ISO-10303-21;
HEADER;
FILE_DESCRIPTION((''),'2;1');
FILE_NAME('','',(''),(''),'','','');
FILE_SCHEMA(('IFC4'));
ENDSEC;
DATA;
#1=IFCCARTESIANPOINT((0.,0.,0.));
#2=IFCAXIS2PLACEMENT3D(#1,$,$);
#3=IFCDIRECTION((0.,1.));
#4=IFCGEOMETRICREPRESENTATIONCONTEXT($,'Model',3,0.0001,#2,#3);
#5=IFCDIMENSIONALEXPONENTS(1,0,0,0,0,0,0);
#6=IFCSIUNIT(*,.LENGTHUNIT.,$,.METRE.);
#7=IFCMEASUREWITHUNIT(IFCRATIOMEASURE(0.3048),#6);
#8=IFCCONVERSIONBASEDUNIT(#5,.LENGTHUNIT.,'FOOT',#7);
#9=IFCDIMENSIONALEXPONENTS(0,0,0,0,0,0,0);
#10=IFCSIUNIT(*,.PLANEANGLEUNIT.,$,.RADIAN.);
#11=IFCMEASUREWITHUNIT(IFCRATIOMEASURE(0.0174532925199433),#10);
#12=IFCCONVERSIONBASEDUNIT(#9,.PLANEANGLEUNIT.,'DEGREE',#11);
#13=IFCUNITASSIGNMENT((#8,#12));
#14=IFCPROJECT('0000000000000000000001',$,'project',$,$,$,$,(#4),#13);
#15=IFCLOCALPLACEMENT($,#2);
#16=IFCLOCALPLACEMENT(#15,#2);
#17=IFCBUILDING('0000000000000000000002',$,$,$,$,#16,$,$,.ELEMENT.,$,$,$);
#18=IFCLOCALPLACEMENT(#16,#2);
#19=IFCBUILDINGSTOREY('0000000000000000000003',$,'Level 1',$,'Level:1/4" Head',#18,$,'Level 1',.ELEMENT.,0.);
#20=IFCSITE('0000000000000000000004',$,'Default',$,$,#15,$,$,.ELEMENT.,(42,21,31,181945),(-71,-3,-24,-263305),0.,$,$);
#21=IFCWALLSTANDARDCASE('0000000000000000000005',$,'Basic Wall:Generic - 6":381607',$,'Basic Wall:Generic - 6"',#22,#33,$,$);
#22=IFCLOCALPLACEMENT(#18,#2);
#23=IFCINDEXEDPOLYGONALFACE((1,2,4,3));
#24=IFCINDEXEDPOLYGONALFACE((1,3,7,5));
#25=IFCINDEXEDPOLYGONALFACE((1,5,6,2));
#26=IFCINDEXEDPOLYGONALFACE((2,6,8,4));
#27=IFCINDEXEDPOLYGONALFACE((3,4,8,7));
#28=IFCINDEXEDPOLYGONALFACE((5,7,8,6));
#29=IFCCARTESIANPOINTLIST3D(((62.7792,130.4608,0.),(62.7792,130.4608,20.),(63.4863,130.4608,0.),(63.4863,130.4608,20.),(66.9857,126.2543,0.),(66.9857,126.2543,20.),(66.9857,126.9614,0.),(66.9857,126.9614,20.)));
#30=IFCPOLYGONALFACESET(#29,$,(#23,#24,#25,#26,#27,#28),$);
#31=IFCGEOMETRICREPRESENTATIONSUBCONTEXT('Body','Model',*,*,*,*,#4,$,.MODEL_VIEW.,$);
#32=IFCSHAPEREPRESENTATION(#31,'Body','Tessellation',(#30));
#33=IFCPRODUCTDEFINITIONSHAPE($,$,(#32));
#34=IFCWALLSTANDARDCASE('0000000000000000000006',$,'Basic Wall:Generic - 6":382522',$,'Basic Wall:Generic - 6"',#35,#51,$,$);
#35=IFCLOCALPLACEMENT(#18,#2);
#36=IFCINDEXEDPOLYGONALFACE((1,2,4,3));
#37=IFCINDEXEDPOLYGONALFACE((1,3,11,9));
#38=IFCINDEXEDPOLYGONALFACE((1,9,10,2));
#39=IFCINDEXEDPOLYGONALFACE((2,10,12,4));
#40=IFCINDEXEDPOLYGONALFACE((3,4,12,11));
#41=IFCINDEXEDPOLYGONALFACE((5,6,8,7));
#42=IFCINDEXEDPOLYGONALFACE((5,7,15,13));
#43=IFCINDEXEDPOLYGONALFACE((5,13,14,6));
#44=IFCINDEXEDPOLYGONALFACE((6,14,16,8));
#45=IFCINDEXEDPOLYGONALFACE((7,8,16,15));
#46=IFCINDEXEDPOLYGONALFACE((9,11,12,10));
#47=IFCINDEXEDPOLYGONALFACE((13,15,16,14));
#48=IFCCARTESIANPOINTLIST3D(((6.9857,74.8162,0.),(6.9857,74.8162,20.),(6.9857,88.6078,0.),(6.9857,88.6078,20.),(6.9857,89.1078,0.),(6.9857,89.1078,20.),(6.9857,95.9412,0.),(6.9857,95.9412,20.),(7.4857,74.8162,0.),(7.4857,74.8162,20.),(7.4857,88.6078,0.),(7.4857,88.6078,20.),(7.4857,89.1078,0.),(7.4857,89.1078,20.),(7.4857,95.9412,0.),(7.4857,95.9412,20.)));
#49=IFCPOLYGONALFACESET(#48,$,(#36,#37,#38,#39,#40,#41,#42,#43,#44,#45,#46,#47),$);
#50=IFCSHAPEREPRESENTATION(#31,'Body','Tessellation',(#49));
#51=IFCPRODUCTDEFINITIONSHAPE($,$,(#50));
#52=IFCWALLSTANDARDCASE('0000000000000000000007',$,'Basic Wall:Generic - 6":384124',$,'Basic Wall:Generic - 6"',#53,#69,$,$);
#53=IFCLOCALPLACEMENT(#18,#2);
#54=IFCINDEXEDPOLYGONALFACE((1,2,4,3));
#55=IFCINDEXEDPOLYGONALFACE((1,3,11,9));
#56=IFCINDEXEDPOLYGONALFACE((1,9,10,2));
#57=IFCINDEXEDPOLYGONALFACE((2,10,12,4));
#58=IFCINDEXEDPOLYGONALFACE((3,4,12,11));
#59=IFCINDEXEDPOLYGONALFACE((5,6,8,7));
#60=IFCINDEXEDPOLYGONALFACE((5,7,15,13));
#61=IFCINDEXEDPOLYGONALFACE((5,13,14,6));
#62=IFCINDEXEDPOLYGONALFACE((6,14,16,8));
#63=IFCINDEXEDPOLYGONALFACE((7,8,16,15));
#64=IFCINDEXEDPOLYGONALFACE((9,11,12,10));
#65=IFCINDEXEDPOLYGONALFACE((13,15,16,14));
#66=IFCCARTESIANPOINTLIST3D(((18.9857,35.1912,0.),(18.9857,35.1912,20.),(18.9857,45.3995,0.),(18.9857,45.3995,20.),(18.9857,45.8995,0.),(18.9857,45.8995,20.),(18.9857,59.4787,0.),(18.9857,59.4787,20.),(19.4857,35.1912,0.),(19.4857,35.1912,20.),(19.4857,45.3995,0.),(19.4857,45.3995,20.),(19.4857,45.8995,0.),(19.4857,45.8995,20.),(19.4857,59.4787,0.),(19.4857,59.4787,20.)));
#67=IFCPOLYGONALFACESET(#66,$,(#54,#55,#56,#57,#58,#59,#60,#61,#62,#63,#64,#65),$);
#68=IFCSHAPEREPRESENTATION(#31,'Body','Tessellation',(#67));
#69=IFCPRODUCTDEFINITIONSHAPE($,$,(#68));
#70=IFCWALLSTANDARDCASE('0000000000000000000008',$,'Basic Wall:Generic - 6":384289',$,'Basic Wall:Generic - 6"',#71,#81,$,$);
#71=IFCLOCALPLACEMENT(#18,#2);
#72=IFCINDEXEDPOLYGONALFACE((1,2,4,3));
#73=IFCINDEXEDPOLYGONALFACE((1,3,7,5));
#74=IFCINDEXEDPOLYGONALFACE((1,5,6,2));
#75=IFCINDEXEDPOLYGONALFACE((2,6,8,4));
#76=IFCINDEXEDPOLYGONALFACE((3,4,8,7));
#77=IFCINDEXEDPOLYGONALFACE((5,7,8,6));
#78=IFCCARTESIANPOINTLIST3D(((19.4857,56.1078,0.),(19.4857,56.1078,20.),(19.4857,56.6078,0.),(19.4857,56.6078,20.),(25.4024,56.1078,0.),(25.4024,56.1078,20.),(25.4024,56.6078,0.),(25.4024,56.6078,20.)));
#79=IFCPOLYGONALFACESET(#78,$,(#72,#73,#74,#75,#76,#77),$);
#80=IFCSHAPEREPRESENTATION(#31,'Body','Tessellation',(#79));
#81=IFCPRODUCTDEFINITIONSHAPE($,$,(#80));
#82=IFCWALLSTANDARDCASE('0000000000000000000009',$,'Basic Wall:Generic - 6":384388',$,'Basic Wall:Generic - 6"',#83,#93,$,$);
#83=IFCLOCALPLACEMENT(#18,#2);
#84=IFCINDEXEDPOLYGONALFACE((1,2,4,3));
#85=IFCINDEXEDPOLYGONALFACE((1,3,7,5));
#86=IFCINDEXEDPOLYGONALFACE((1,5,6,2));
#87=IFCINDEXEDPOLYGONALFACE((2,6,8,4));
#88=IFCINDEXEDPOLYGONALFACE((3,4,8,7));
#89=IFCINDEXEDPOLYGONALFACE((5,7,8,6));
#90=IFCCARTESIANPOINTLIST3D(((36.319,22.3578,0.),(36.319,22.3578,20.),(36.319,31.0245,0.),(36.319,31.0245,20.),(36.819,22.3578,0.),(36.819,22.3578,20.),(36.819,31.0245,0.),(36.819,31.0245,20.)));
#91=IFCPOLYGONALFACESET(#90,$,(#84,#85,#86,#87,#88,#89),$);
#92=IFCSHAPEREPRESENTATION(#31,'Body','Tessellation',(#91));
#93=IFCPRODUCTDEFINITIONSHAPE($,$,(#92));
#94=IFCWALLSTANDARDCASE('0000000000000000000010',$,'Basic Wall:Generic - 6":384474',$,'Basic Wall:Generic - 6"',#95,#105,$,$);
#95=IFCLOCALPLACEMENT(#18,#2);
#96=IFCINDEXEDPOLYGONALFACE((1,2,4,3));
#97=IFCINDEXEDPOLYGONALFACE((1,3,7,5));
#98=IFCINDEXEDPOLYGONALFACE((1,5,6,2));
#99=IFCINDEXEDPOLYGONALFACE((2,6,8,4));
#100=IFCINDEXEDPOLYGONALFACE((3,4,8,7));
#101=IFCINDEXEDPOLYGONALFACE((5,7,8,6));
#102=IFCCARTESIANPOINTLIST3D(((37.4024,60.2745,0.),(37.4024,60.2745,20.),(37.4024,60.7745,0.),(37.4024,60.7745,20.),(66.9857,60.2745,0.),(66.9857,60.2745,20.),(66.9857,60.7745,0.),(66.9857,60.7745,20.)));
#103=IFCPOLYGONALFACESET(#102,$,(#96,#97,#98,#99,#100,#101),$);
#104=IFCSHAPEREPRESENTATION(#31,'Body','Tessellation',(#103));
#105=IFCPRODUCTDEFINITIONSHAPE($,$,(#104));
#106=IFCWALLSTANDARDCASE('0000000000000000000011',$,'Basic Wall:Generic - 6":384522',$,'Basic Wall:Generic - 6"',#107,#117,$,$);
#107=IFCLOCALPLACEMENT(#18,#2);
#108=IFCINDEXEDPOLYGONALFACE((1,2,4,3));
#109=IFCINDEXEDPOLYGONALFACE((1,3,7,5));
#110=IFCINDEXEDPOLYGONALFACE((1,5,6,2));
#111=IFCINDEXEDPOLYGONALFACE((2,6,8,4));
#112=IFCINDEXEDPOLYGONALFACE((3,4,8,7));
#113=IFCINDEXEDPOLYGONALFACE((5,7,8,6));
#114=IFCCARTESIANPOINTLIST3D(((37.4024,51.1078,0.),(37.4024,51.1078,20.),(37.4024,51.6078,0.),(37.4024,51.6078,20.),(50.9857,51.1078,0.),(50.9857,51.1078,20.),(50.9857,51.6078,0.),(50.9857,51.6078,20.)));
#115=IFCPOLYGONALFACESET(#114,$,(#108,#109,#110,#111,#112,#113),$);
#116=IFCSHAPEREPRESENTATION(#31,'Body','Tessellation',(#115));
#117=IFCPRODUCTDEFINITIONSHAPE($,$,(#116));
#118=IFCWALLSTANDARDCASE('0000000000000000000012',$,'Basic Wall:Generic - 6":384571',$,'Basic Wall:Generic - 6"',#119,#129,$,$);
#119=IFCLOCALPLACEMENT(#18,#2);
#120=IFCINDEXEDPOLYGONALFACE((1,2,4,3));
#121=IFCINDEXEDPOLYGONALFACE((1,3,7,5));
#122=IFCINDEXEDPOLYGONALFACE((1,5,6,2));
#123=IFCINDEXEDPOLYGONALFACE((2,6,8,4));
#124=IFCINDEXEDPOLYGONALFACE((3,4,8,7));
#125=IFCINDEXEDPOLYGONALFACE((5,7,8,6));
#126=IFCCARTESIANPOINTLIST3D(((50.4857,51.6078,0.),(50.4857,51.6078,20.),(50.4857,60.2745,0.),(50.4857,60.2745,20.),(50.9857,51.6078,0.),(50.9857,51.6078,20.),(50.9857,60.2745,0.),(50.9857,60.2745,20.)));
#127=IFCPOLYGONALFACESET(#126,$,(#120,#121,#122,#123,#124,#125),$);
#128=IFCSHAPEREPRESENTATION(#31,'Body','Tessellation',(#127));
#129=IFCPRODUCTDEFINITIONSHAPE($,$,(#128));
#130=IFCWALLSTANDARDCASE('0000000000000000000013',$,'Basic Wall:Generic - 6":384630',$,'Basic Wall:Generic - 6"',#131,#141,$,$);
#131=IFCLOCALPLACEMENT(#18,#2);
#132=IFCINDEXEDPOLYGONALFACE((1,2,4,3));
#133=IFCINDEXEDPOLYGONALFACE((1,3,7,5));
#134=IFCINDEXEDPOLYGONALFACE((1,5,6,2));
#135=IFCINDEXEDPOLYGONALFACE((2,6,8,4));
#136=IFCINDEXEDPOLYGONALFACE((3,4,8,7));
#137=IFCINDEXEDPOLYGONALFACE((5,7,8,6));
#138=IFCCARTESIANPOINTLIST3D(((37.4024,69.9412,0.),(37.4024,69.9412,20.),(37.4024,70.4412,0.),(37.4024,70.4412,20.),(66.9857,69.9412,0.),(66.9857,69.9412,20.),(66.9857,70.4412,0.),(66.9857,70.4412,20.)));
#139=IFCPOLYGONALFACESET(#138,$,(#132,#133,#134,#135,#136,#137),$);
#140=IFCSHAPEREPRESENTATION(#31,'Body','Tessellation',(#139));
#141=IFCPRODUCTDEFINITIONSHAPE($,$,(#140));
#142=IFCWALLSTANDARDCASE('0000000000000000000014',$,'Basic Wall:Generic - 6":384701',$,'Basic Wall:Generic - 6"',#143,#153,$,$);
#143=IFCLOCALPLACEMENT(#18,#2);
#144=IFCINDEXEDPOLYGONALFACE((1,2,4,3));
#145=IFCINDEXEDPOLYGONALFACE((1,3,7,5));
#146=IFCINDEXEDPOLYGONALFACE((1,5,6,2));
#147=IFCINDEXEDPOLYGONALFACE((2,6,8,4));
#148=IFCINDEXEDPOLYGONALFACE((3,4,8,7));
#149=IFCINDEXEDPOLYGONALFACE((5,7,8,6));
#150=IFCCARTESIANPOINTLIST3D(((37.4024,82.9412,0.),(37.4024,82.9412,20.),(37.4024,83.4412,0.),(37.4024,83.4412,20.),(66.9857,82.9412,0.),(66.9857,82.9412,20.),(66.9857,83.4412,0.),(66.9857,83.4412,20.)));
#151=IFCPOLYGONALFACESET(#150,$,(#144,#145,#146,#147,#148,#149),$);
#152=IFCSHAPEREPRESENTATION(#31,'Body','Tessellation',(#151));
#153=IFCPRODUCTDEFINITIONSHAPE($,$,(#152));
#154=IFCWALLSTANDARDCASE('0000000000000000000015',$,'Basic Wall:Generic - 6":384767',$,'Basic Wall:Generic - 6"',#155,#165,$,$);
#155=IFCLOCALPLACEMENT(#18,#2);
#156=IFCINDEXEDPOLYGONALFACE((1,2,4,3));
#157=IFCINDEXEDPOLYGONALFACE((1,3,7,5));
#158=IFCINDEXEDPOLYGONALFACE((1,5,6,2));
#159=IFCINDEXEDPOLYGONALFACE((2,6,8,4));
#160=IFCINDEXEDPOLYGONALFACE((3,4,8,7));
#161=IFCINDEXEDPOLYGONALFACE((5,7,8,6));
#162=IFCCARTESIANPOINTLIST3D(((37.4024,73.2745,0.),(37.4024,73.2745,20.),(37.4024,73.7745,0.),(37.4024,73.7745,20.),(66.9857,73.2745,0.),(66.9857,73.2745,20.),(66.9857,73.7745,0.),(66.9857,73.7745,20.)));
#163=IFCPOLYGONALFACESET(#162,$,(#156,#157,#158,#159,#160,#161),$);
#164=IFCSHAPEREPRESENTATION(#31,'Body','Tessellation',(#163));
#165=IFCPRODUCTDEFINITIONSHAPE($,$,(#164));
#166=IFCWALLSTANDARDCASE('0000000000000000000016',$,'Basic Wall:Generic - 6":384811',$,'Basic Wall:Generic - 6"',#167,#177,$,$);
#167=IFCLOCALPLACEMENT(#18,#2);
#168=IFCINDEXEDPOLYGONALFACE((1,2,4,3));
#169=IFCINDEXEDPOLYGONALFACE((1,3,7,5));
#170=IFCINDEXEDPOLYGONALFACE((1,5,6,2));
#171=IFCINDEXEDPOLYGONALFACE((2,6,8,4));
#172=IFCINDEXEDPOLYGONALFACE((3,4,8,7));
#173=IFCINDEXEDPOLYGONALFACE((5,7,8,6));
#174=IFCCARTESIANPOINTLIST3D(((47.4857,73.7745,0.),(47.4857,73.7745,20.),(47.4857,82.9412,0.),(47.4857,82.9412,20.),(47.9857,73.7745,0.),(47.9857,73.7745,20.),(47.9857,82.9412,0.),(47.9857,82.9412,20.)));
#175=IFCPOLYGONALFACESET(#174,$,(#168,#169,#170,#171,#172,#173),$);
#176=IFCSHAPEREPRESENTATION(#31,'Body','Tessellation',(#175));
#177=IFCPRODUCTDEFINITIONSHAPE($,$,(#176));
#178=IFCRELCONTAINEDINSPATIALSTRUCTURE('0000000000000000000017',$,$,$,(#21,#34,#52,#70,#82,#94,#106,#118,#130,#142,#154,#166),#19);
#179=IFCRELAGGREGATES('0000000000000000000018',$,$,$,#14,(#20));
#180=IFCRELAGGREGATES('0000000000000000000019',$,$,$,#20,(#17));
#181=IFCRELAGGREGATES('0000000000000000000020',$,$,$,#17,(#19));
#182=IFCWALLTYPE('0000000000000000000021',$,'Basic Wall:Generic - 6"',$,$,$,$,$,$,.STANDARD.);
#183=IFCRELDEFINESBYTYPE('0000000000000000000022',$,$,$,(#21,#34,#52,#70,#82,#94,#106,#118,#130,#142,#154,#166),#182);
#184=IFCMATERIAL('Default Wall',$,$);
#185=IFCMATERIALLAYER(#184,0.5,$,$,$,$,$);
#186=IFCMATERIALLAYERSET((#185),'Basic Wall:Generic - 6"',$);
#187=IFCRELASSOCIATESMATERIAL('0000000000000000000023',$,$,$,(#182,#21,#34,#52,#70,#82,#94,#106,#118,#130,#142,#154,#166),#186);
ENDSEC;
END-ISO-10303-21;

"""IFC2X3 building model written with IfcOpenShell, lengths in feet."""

from ifc_helpers import new_model, entity, si_unit, converted_unit, direction, frame, frame_2d, origin, origin_2d_with_axis, place, context, subcontext, project, spatial, polyline, rectangle, outline, extrude, material, layer, layer_set, layer_usage, type_object, element, save


model = new_model("IFC2X3")

# Units and contexts
model_context = context("Model", 3, precision=0.0001, world=origin(), true_north=direction((0.0, 1.0)))
body_context = subcontext(model_context, "Body", "Model", "MODEL_VIEW")
ifc_project = project(units=[converted_unit("LENGTHUNIT", "FOOT", entity("IfcRatioMeasure", 0.3048), si_unit("LENGTHUNIT", "METRE"), dimensions=[1, 0, 0, 0, 0, 0, 0]), converted_unit("PLANEANGLEUNIT", "DEGREE", entity("IfcRatioMeasure", 0.0174532925199433), si_unit("PLANEANGLEUNIT", "RADIAN"), dimensions=[0, 0, 0, 0, 0, 0, 0])], contexts=[model_context])

# Site, building, storey
site_placement = place(None, origin())
site = spatial("IfcSite", under=ifc_project, at=site_placement, Name="Default", CompositionType="ELEMENT", RefLatitude=(42, 21, 31, 181945), RefLongitude=(-71, -3, -24, -263305), RefElevation=0.0)
building_placement = place(site_placement, origin())
building = spatial("IfcBuilding", under=site, at=building_placement, CompositionType="ELEMENT")
storey_placement = place(building_placement, origin())
storey = spatial("IfcBuildingStorey", under=building, at=storey_placement, Name="Level 1", ObjectType="Level:1/4\" Head", LongName="Level 1", CompositionType="ELEMENT", Elevation=0.0)

# Wall
ifc_material = material(Name="Default Wall")
ifc_layer_1 = layer(ifc_material, 0.5)
ifc_layer_set_1 = layer_set([ifc_layer_1], Name="Basic Wall:Generic - 6\"")
wall_type_1 = type_object("IfcWallType", Name="Basic Wall:Generic - 6\"", PredefinedType="STANDARD", material=ifc_layer_set_1)
ifc_layer_usage_1 = layer_usage(ifc_layer_set_1, "AXIS2", "NEGATIVE", 0.25)
wall_1_placement = place(storey_placement, frame((67.1625, 126.4311, 0.0), z_axis=(0.0, 0.0, 1.0), x_axis=(-0.707107, 0.707107, 0.0)))
element("IfcWallStandardCase", 1, at=wall_1_placement, inside=storey, type_object=wall_type_1, material=ifc_layer_usage_1, Name="Basic Wall:Generic - 6\":381607", ObjectType="Basic Wall:Generic - 6\"", context=body_context, shape_type="SweptSolid", body=[
    extrude(outline(polyline([(5.4489, -0.25), (5.9489, 0.25), (0.0, 0.25), (0.5, -0.25), (5.4489, -0.25)])), origin(), (0.0, 0.0, 1.0), 20.0),
])

# Walls, openings
ifc_layer_usage_2 = layer_usage(ifc_layer_set_1, "AXIS2", "NEGATIVE", 0.25)
wall_2_placement = place(storey_placement, frame((7.2357, 95.9412, 0.0), z_axis=(0.0, 0.0, 1.0), x_axis=(0.0, -1.0, 0.0)))
wall_2 = element("IfcWallStandardCase", 2, at=wall_2_placement, inside=storey, type_object=wall_type_1, material=ifc_layer_usage_2, Name="Basic Wall:Generic - 6\":382522", ObjectType="Basic Wall:Generic - 6\"", context=body_context, shape_type="SweptSolid", body=[
    extrude(rectangle(XDim=21.125, YDim=0.5, at=frame_2d((10.5625, 0.0), x_axis=(-1.0, 0.0))), origin(), (0.0, 0.0, 1.0), 20.0),
])
opening_1_placement = place(storey_placement, frame((7.2357, 95.9412, 0.0), z_axis=(0.0, 0.0, 1.0), x_axis=(0.0, -1.0, 0.0)))
element("IfcOpeningElement", 3, at=opening_1_placement, cuts=wall_2, ObjectType="Opening", context=body_context, shape_type="SweptSolid", body=[
    extrude(rectangle(XDim=20.0, YDim=0.5, at=frame_2d((0.0, 0.0), x_axis=(1.0, 0.0))), frame((7.3333, 0.0, 10.0), z_axis=(-1.0, 0.0, 0.0), x_axis=(0.0, 0.0, 1.0)), (0.0, 0.0, 1.0), 0.5),
])
ifc_layer_usage_3 = layer_usage(ifc_layer_set_1, "AXIS2", "NEGATIVE", 0.25)
wall_3_placement = place(storey_placement, frame((19.2357, 35.1912, 0.0), z_axis=(0.0, 0.0, 1.0), x_axis=(0.0, 1.0, 0.0)))
wall_3 = element("IfcWallStandardCase", 4, at=wall_3_placement, inside=storey, type_object=wall_type_1, material=ifc_layer_usage_3, Name="Basic Wall:Generic - 6\":384124", ObjectType="Basic Wall:Generic - 6\"", context=body_context, shape_type="SweptSolid", body=[
    extrude(rectangle(XDim=24.2875, YDim=0.5, at=frame_2d((12.1438, 0.0), x_axis=(-1.0, 0.0))), origin(), (0.0, 0.0, 1.0), 20.0),
])
opening_2_placement = place(storey_placement, frame((19.2357, 35.1912, 0.0), z_axis=(0.0, 0.0, 1.0), x_axis=(0.0, 1.0, 0.0)))
element("IfcOpeningElement", 5, at=opening_2_placement, cuts=wall_3, ObjectType="Opening", context=body_context, shape_type="SweptSolid", body=[
    extrude(rectangle(XDim=20.0, YDim=0.5, at=origin_2d_with_axis()), frame((10.2083, 0.0, 10.0), z_axis=(1.0, 0.0, 0.0), x_axis=(0.0, 0.0, -1.0)), (0.0, 0.0, 1.0), 0.5),
])

# Walls
ifc_layer_usage_4 = layer_usage(ifc_layer_set_1, "AXIS2", "NEGATIVE", 0.25)
wall_4_placement = place(storey_placement, frame((19.4857, 56.3578, 0.0)))
element("IfcWallStandardCase", 6, at=wall_4_placement, inside=storey, type_object=wall_type_1, material=ifc_layer_usage_4, Name="Basic Wall:Generic - 6\":384289", ObjectType="Basic Wall:Generic - 6\"", context=body_context, shape_type="SweptSolid", body=[
    extrude(rectangle(XDim=5.9167, YDim=0.5, at=frame_2d((2.9583, 0.0), x_axis=(-1.0, 0.0))), origin(), (0.0, 0.0, 1.0), 20.0),
])
ifc_layer_usage_5 = layer_usage(ifc_layer_set_1, "AXIS2", "NEGATIVE", 0.25)
wall_5_placement = place(storey_placement, frame((36.569, 31.0245, 0.0), z_axis=(0.0, 0.0, 1.0), x_axis=(0.0, -1.0, 0.0)))
element("IfcWallStandardCase", 7, at=wall_5_placement, inside=storey, type_object=wall_type_1, material=ifc_layer_usage_5, Name="Basic Wall:Generic - 6\":384388", ObjectType="Basic Wall:Generic - 6\"", context=body_context, shape_type="SweptSolid", body=[
    extrude(rectangle(XDim=8.6667, YDim=0.5, at=frame_2d((4.3333, 0.0), x_axis=(-1.0, 0.0))), origin(), (0.0, 0.0, 1.0), 20.0),
])
ifc_layer_usage_6 = layer_usage(ifc_layer_set_1, "AXIS2", "NEGATIVE", 0.25)
wall_6_placement = place(storey_placement, frame((37.4024, 60.5245, 0.0)))
element("IfcWallStandardCase", 8, at=wall_6_placement, inside=storey, type_object=wall_type_1, material=ifc_layer_usage_6, Name="Basic Wall:Generic - 6\":384474", ObjectType="Basic Wall:Generic - 6\"", context=body_context, shape_type="SweptSolid", body=[
    extrude(rectangle(XDim=29.5833, YDim=0.5, at=frame_2d((14.7917, 0.0), x_axis=(-1.0, 0.0))), origin(), (0.0, 0.0, 1.0), 20.0),
])
ifc_layer_usage_7 = layer_usage(ifc_layer_set_1, "AXIS2", "NEGATIVE", 0.25)
wall_7_placement = place(storey_placement, frame((37.4024, 51.3578, 0.0)))
element("IfcWallStandardCase", 9, at=wall_7_placement, inside=storey, type_object=wall_type_1, material=ifc_layer_usage_7, Name="Basic Wall:Generic - 6\":384522", ObjectType="Basic Wall:Generic - 6\"", context=body_context, shape_type="SweptSolid", body=[
    extrude(rectangle(XDim=13.5833, YDim=0.5, at=frame_2d((6.7917, 0.0), x_axis=(-1.0, 0.0))), origin(), (0.0, 0.0, 1.0), 20.0),
])
ifc_layer_usage_8 = layer_usage(ifc_layer_set_1, "AXIS2", "NEGATIVE", 0.25)
wall_8_placement = place(storey_placement, frame((50.7357, 51.6078, 0.0), z_axis=(0.0, 0.0, 1.0), x_axis=(0.0, 1.0, 0.0)))
element("IfcWallStandardCase", 10, at=wall_8_placement, inside=storey, type_object=wall_type_1, material=ifc_layer_usage_8, Name="Basic Wall:Generic - 6\":384571", ObjectType="Basic Wall:Generic - 6\"", context=body_context, shape_type="SweptSolid", body=[
    extrude(rectangle(XDim=8.6667, YDim=0.5, at=frame_2d((4.3333, 0.0), x_axis=(-1.0, 0.0))), origin(), (0.0, 0.0, 1.0), 20.0),
])
ifc_layer_usage_9 = layer_usage(ifc_layer_set_1, "AXIS2", "NEGATIVE", 0.25)
wall_9_placement = place(storey_placement, frame((37.4024, 70.1912, 0.0)))
element("IfcWallStandardCase", 11, at=wall_9_placement, inside=storey, type_object=wall_type_1, material=ifc_layer_usage_9, Name="Basic Wall:Generic - 6\":384630", ObjectType="Basic Wall:Generic - 6\"", context=body_context, shape_type="SweptSolid", body=[
    extrude(rectangle(XDim=29.5833, YDim=0.5, at=frame_2d((14.7917, 0.0), x_axis=(-1.0, 0.0))), origin(), (0.0, 0.0, 1.0), 20.0),
])
ifc_layer_usage_10 = layer_usage(ifc_layer_set_1, "AXIS2", "NEGATIVE", 0.25)
wall_10_placement = place(storey_placement, frame((37.4024, 83.1912, 0.0)))
element("IfcWallStandardCase", 12, at=wall_10_placement, inside=storey, type_object=wall_type_1, material=ifc_layer_usage_10, Name="Basic Wall:Generic - 6\":384701", ObjectType="Basic Wall:Generic - 6\"", context=body_context, shape_type="SweptSolid", body=[
    extrude(rectangle(XDim=29.5833, YDim=0.5, at=frame_2d((14.7917, 0.0), x_axis=(-1.0, 0.0))), origin(), (0.0, 0.0, 1.0), 20.0),
])
ifc_layer_usage_11 = layer_usage(ifc_layer_set_1, "AXIS2", "NEGATIVE", 0.25)
wall_11_placement = place(storey_placement, frame((37.4024, 73.5245, 0.0)))
element("IfcWallStandardCase", 13, at=wall_11_placement, inside=storey, type_object=wall_type_1, material=ifc_layer_usage_11, Name="Basic Wall:Generic - 6\":384767", ObjectType="Basic Wall:Generic - 6\"", context=body_context, shape_type="SweptSolid", body=[
    extrude(rectangle(XDim=29.5833, YDim=0.5, at=frame_2d((14.7917, 0.0), x_axis=(-1.0, 0.0))), origin(), (0.0, 0.0, 1.0), 20.0),
])
ifc_layer_usage_12 = layer_usage(ifc_layer_set_1, "AXIS2", "NEGATIVE", 0.25)
wall_12_placement = place(storey_placement, frame((47.7357, 82.9412, 0.0), z_axis=(0.0, 0.0, 1.0), x_axis=(0.0, -1.0, 0.0)))
element("IfcWallStandardCase", 14, at=wall_12_placement, inside=storey, type_object=wall_type_1, material=ifc_layer_usage_12, Name="Basic Wall:Generic - 6\":384811", ObjectType="Basic Wall:Generic - 6\"", context=body_context, shape_type="SweptSolid", body=[
    extrude(rectangle(XDim=9.1667, YDim=0.5, at=frame_2d((4.5833, 0.0), x_axis=(-1.0, 0.0))), origin(), (0.0, 0.0, 1.0), 20.0),
])

save(model, "model.ifc")
